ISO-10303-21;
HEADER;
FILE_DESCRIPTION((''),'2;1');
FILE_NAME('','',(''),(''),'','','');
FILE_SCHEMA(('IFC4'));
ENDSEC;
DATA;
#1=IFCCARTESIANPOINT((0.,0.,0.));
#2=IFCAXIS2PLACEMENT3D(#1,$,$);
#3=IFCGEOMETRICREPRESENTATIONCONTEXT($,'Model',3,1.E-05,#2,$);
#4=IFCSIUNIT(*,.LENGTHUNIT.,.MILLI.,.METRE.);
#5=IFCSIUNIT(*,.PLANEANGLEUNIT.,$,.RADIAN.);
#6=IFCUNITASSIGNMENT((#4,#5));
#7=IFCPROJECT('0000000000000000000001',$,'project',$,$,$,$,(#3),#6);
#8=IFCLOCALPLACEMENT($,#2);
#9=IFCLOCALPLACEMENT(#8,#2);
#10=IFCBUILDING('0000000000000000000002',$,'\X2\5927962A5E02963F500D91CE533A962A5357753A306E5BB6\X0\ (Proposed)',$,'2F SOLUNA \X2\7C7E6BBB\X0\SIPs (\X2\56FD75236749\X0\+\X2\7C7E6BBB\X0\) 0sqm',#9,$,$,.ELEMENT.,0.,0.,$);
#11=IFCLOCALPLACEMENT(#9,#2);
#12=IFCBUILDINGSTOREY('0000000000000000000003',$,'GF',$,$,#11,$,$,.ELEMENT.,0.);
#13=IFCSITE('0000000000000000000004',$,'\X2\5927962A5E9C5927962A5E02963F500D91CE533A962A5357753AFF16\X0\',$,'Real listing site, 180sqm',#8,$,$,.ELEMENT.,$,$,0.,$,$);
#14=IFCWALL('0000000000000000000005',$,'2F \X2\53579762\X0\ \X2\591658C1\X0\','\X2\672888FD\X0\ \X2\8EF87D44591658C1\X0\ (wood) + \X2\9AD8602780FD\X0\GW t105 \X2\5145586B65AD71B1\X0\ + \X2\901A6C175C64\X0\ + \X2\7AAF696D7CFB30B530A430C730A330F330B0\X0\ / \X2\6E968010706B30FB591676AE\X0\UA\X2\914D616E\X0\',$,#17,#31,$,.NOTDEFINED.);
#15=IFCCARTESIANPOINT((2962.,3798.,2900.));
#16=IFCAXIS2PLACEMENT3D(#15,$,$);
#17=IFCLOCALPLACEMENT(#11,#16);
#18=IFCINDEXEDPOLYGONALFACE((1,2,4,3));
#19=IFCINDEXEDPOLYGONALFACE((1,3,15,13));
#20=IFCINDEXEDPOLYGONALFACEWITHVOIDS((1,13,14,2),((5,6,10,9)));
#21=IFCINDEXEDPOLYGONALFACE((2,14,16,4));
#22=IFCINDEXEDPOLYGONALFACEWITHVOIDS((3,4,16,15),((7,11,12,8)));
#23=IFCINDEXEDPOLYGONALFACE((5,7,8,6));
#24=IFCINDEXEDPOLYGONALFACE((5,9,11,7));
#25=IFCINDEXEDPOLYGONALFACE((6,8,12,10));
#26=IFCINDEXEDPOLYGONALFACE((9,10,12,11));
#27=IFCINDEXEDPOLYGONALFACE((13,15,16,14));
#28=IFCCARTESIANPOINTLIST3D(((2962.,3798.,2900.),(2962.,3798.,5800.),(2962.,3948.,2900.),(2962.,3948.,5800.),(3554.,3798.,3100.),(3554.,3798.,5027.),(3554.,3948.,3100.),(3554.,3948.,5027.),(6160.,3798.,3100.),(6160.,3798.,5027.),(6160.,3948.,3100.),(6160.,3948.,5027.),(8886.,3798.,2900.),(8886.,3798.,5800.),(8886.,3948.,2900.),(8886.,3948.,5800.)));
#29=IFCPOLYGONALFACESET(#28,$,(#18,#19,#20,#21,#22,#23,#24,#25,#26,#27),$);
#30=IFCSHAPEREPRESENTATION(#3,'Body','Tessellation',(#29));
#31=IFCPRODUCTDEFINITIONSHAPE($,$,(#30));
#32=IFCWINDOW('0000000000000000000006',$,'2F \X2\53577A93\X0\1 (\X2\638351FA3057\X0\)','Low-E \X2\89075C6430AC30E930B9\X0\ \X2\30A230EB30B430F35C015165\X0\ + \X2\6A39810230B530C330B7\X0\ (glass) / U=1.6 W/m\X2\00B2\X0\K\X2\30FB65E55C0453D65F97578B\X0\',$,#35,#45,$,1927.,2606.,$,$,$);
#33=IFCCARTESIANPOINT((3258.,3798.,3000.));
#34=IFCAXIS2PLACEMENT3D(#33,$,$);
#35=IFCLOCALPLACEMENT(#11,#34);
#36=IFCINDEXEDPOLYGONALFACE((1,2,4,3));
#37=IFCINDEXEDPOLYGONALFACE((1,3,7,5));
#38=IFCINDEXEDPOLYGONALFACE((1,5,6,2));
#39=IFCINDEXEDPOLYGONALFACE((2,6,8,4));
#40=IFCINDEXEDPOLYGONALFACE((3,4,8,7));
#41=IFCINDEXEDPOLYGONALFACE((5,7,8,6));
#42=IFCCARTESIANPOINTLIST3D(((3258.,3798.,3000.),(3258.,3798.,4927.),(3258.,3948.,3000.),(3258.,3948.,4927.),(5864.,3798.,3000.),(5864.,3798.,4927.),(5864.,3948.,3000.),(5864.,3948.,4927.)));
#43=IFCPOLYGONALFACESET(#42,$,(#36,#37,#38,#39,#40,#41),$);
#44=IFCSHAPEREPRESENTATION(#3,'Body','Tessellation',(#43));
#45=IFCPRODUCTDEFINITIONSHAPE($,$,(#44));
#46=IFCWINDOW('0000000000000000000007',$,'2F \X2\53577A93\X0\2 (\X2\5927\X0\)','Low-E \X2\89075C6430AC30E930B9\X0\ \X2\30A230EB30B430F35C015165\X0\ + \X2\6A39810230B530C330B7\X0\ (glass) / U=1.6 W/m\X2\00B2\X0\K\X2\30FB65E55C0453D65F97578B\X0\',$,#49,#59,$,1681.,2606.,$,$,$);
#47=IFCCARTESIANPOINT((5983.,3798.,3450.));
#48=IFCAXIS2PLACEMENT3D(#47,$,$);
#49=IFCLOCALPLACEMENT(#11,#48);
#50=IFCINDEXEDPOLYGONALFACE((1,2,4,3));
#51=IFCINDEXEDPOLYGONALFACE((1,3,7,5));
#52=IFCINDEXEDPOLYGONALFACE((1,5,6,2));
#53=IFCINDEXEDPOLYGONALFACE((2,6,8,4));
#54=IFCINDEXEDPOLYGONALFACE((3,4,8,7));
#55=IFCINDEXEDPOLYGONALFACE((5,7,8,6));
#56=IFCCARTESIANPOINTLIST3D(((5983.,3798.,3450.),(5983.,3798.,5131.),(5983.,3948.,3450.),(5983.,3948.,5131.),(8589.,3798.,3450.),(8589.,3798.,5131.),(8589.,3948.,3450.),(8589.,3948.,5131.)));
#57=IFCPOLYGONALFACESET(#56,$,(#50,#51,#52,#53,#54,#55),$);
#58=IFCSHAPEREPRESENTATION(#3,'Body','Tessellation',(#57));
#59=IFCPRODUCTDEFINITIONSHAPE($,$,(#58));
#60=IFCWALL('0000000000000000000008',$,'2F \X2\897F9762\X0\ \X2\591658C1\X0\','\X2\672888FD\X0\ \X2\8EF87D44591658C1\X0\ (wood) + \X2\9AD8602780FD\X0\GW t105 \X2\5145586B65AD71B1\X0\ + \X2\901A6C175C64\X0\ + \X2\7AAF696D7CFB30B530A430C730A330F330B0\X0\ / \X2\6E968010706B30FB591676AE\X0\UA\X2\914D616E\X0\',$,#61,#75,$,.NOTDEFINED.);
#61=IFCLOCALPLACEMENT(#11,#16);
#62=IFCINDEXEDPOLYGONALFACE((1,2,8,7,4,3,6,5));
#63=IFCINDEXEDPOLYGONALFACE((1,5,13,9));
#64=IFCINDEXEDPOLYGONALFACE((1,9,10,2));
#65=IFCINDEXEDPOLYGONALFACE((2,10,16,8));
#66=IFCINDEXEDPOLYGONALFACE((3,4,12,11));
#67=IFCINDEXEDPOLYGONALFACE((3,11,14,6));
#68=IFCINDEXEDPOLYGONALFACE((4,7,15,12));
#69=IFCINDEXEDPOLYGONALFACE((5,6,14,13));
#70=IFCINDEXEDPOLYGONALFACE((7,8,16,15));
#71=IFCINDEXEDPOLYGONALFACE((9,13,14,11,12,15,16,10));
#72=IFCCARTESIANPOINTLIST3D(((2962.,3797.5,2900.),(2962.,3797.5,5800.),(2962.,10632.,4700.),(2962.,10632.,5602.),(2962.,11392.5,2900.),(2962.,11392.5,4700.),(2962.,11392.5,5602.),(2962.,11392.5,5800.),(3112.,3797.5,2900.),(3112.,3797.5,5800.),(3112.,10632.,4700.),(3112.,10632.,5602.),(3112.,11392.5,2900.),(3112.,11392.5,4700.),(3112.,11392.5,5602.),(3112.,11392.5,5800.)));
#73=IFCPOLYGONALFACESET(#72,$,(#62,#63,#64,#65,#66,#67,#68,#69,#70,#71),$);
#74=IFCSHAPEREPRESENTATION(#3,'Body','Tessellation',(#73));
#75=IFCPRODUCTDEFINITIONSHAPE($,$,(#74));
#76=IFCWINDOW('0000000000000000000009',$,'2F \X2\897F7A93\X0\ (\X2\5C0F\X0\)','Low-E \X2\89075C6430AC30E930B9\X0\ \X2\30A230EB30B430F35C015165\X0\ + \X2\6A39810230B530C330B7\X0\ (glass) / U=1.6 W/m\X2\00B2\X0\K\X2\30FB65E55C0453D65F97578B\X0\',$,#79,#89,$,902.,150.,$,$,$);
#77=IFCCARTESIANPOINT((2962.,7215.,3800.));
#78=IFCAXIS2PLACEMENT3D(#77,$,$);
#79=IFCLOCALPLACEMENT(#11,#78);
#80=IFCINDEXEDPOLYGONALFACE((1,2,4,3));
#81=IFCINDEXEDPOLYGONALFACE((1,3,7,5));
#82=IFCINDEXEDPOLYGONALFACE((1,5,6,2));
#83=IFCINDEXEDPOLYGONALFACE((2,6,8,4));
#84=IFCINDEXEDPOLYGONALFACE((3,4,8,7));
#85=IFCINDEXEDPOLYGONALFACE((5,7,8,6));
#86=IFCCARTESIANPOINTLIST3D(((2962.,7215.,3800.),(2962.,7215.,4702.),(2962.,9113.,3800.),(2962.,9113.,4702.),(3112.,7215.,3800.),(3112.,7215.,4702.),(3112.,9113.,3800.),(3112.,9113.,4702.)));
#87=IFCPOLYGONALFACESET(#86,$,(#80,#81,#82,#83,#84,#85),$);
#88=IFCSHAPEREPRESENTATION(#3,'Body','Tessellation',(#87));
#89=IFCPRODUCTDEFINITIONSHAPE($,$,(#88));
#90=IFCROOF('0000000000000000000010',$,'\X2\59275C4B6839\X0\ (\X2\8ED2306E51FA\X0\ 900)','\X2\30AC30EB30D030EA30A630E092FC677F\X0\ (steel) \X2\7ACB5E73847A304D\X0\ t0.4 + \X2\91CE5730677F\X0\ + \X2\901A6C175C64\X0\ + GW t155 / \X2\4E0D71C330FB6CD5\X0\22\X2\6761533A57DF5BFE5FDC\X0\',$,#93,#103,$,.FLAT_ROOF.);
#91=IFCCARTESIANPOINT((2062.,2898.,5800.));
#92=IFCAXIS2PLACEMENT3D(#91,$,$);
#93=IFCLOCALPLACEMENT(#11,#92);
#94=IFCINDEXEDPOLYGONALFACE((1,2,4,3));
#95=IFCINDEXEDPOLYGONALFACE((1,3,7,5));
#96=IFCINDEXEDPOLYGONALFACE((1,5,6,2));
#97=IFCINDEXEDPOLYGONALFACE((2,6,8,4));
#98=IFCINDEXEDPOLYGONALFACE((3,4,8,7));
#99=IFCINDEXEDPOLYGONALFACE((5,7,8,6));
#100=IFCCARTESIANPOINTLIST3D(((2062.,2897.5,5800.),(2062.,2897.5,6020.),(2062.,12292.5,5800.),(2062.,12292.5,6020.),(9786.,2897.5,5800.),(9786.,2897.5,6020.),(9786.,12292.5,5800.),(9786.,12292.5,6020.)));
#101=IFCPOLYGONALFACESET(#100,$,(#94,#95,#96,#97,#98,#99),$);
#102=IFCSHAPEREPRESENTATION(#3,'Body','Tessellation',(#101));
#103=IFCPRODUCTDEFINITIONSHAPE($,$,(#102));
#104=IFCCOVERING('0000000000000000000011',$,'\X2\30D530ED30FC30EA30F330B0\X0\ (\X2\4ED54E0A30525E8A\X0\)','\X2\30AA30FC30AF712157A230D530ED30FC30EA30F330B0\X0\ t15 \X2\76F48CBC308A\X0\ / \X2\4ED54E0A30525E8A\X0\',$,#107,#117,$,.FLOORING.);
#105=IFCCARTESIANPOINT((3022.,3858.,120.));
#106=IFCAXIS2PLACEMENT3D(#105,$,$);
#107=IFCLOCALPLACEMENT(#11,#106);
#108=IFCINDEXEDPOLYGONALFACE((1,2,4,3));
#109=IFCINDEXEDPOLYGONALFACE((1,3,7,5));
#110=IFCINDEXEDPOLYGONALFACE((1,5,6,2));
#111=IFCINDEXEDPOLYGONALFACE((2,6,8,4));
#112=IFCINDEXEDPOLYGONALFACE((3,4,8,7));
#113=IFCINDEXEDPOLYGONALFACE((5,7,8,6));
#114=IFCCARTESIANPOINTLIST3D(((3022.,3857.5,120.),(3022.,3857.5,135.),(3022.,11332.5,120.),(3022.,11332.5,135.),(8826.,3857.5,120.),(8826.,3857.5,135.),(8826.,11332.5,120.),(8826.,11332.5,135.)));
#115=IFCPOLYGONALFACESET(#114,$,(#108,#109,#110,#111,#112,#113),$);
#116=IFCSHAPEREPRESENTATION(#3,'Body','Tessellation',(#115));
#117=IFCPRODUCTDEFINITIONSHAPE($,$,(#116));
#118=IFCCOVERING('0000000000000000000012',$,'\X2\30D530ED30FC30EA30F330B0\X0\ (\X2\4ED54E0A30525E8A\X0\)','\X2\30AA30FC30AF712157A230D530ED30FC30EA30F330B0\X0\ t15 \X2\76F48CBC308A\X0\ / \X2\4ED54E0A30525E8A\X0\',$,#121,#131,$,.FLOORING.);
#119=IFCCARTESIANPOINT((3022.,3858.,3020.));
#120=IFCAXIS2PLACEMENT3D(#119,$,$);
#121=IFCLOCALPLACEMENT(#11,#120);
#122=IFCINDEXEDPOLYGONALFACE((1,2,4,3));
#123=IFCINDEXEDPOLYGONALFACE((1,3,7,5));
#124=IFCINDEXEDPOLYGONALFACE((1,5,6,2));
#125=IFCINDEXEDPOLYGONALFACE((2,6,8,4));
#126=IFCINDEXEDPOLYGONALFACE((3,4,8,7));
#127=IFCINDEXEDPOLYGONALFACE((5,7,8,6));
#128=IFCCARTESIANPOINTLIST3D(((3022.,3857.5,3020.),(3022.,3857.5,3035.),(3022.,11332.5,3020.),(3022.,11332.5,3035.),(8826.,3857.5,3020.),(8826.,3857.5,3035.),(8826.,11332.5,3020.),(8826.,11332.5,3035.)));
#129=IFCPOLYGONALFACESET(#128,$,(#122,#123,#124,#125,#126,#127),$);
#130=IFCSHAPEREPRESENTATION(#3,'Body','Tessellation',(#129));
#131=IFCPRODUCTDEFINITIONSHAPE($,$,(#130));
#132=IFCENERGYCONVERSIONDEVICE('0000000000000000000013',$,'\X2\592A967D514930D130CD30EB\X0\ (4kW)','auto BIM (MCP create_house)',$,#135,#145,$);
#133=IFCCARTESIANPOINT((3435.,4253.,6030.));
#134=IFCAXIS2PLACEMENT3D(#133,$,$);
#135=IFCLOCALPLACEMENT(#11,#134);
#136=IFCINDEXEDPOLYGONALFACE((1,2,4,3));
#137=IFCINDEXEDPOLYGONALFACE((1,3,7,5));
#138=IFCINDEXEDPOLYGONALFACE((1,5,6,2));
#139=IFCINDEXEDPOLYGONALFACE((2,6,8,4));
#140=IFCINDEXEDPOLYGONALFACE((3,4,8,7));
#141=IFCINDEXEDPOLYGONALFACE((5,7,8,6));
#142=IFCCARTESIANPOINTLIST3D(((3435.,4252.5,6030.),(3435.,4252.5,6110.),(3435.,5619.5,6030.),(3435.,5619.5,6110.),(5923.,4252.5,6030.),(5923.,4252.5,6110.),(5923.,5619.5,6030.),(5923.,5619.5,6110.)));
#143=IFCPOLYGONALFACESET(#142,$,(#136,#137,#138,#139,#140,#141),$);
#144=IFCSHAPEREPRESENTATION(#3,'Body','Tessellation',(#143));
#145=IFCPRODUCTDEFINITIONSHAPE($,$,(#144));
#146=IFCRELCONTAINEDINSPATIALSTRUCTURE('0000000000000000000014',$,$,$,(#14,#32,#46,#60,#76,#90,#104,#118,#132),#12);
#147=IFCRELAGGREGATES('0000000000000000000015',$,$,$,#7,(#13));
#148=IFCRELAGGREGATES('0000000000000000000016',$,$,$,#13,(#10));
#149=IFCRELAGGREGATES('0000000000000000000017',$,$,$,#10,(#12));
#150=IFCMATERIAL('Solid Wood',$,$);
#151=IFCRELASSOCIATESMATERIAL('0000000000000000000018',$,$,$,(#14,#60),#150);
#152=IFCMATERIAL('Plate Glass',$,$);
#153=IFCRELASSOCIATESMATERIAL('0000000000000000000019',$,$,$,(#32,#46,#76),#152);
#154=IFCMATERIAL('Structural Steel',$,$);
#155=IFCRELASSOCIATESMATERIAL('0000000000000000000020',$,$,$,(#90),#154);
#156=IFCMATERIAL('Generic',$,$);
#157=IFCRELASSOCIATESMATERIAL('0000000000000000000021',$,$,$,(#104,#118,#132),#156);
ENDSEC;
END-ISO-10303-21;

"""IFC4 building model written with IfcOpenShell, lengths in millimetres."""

from ifc_helpers import new_model, si_unit, frame, frame_2d, origin, place, context, project, spatial, rectangle, extrude, material, element, fill, save


model = new_model("IFC4")

# Units and contexts
model_context = context("Model", 3, precision=1e-05, world=origin())
ifc_project = project(units=[si_unit("LENGTHUNIT", "METRE", prefix="MILLI"), si_unit("PLANEANGLEUNIT", "RADIAN")], contexts=[model_context])

# Site, building, storey
site_placement = place(None, origin())
site = spatial("IfcSite", under=ifc_project, at=site_placement, Name="大阪府大阪市阿倍野区阪南町６", ObjectType="Real listing site, 180sqm", CompositionType="ELEMENT", RefElevation=0.0)
building_placement = place(site_placement, origin())
building = spatial("IfcBuilding", under=site, at=building_placement, Name="大阪市阿倍野区阪南町の家 (Proposed)", ObjectType="2F SOLUNA 籾殻SIPs (国産杉+籾殻) 0sqm", CompositionType="ELEMENT", ElevationOfRefHeight=0.0, ElevationOfTerrain=0.0)
storey_placement = place(building_placement, origin())
storey = spatial("IfcBuildingStorey", under=building, at=storey_placement, Name="GF", CompositionType="ELEMENT", Elevation=0.0)

# Shared definitions
ifc_material_1 = material(Name="Solid Wood")

# Shared definitions
ifc_material_2 = material(Name="Plate Glass")

# Wall, openings, windows
wall_1_placement = place(storey_placement, frame((2962.0, 3798.0, 2900.0)))
wall_1 = element("IfcWall", 1, at=wall_1_placement, inside=storey, material=ifc_material_1, Name="2F 南面 外壁", Description="木製 軸組外壁 (wood) + 高性能GW t105 充填断熱 + 通気層 + 窯業系サイディング / 準耐火・外皮UA配慮", PredefinedType="NOTDEFINED", context=model_context, shape_type="SweptSolid", body=[
    extrude(rectangle(XDim=5924.0, YDim=150.0, at=frame_2d((2962.0, 75.0))), frame((2962.0, 3798.0, 2900.0)), (0.0, 0.0, 1.0), 2900.0),
])
opening_1_placement = place(storey_placement, frame((3258.0, 3798.0, 3000.0)))
opening_1 = element("IfcOpeningElement", 2, at=opening_1_placement, cuts=wall_1, PredefinedType="NOTDEFINED", context=model_context, shape_type="SweptSolid", body=[
    extrude(rectangle(XDim=2606.0, YDim=150.0, at=frame_2d((1303.0, 75.0))), frame((3258.0, 3798.0, 3000.0)), (0.0, 0.0, 1.0), 1927.0),
])
opening_2_placement = place(storey_placement, frame((5983.0, 3798.0, 3450.0)))
opening_2 = element("IfcOpeningElement", 3, at=opening_2_placement, cuts=wall_1, PredefinedType="NOTDEFINED", context=model_context, shape_type="SweptSolid", body=[
    extrude(rectangle(XDim=2606.0, YDim=150.0, at=frame_2d((1303.0, 75.0))), frame((5983.0, 3798.0, 3450.0)), (0.0, 0.0, 1.0), 1681.0),
])
window_1_placement = place(storey_placement, frame((3258.0, 3798.0, 3000.0)))
window_1 = element("IfcWindow", 4, at=window_1_placement, inside=storey, material=ifc_material_2, Name="2F 南窓1 (掃出し)", Description="Low-E 複層ガラス アルゴン封入 + 樹脂サッシ (glass) / U=1.6 W/m²K・日射取得型", OverallHeight=1927.0, OverallWidth=2606.0, context=model_context, shape_type="SweptSolid", body=[
    extrude(rectangle(XDim=2606.0, YDim=150.0, at=frame_2d((1303.0, 75.0))), frame((3258.0, 3798.0, 3000.0)), (0.0, 0.0, 1.0), 1927.0),
])
fill(opening_1, window_1)
window_2_placement = place(storey_placement, frame((5983.0, 3798.0, 3450.0)))
window_2 = element("IfcWindow", 5, at=window_2_placement, inside=storey, material=ifc_material_2, Name="2F 南窓2 (大)", Description="Low-E 複層ガラス アルゴン封入 + 樹脂サッシ (glass) / U=1.6 W/m²K・日射取得型", OverallHeight=1681.0, OverallWidth=2606.0, context=model_context, shape_type="SweptSolid", body=[
    extrude(rectangle(XDim=2606.0, YDim=150.0, at=frame_2d((1303.0, 75.0))), frame((5983.0, 3798.0, 3450.0)), (0.0, 0.0, 1.0), 1681.0),
])
fill(opening_2, window_2)

# Wall, opening, window
wall_2_placement = place(storey_placement, frame((2962.0, 3798.0, 2900.0)))
wall_2 = element("IfcWall", 6, at=wall_2_placement, inside=storey, material=ifc_material_1, Name="2F 西面 外壁", Description="木製 軸組外壁 (wood) + 高性能GW t105 充填断熱 + 通気層 + 窯業系サイディング / 準耐火・外皮UA配慮", PredefinedType="NOTDEFINED", context=model_context, shape_type="SweptSolid", body=[
    extrude(rectangle(XDim=150.0, YDim=7595.0, at=frame_2d((75.0, 3797.0))), frame((2962.0, 3798.0, 2900.0)), (0.0, 0.0, 1.0), 2900.0),
])
opening_3_placement = place(storey_placement, frame((2962.0, 7215.0, 3800.0)))
opening_3 = element("IfcOpeningElement", 7, at=opening_3_placement, cuts=wall_2, PredefinedType="NOTDEFINED", context=model_context, shape_type="SweptSolid", body=[
    extrude(rectangle(XDim=150.0, YDim=1898.0, at=frame_2d((75.0, 949.0))), frame((2962.0, 7215.0, 3800.0)), (0.0, 0.0, 1.0), 902.0),
])
window_3_placement = place(storey_placement, frame((2962.0, 7215.0, 3800.0)))
window_3 = element("IfcWindow", 8, at=window_3_placement, inside=storey, material=ifc_material_2, Name="2F 西窓 (小)", Description="Low-E 複層ガラス アルゴン封入 + 樹脂サッシ (glass) / U=1.6 W/m²K・日射取得型", OverallHeight=902.0, OverallWidth=150.0, context=model_context, shape_type="SweptSolid", body=[
    extrude(rectangle(XDim=150.0, YDim=1898.0, at=frame_2d((75.0, 949.0))), frame((2962.0, 7215.0, 3800.0)), (0.0, 0.0, 1.0), 902.0),
])
fill(opening_3, window_3)

# Roof
ifc_material_3 = material(Name="Structural Steel")
roof_placement = place(storey_placement, frame((2062.0, 2898.0, 5800.0)))
element("IfcRoof", 9, at=roof_placement, inside=storey, material=ifc_material_3, Name="大屋根 (軒の出 900)", Description="ガルバリウム鋼板 (steel) 立平葺き t0.4 + 野地板 + 通気層 + GW t155 / 不燃・法22条区域対応", PredefinedType="FLAT_ROOF", context=model_context, shape_type="SweptSolid", body=[
    extrude(rectangle(XDim=7724.0, YDim=9395.0, at=frame_2d((3862.0, 4697.0))), frame((2062.0, 2898.0, 5800.0)), (0.0, 0.0, 1.0), 220.0),
])

# Coverings
ifc_material_4 = material(Name="Generic")
covering_1_placement = place(storey_placement, frame((3022.0, 3858.0, 120.0)))
element("IfcCovering", 10, at=covering_1_placement, inside=storey, material=ifc_material_4, Name="フローリング (仕上げ床)", Description="オーク無垢フローリング t15 直貼り / 仕上げ床", PredefinedType="FLOORING", context=model_context, shape_type="SweptSolid", body=[
    extrude(rectangle(XDim=5804.0, YDim=7475.0, at=frame_2d((2902.0, 3737.0))), frame((3022.0, 3858.0, 120.0)), (0.0, 0.0, 1.0), 15.0),
])
covering_2_placement = place(storey_placement, frame((3022.0, 3858.0, 3020.0)))
element("IfcCovering", 11, at=covering_2_placement, inside=storey, material=ifc_material_4, Name="フローリング (仕上げ床)", Description="オーク無垢フローリング t15 直貼り / 仕上げ床", PredefinedType="FLOORING", context=model_context, shape_type="SweptSolid", body=[
    extrude(rectangle(XDim=5804.0, YDim=7475.0, at=frame_2d((2902.0, 3737.0))), frame((3022.0, 3858.0, 3020.0)), (0.0, 0.0, 1.0), 15.0),
])

# Energy conversion device
energy_conversion_device_placement = place(storey_placement, frame((3435.0, 4253.0, 6030.0)))
element("IfcEnergyConversionDevice", 12, at=energy_conversion_device_placement, inside=storey, material=ifc_material_4, Name="太陽光パネル (4kW)", Description="auto BIM (MCP create_house)", context=model_context, shape_type="SweptSolid", body=[
    extrude(rectangle(XDim=2488.0, YDim=1367.0, at=frame_2d((1244.0, 683.0))), frame((3435.0, 4253.0, 6030.0)), (0.0, 0.0, 1.0), 80.0),
])

save(model, "model.ifc")
